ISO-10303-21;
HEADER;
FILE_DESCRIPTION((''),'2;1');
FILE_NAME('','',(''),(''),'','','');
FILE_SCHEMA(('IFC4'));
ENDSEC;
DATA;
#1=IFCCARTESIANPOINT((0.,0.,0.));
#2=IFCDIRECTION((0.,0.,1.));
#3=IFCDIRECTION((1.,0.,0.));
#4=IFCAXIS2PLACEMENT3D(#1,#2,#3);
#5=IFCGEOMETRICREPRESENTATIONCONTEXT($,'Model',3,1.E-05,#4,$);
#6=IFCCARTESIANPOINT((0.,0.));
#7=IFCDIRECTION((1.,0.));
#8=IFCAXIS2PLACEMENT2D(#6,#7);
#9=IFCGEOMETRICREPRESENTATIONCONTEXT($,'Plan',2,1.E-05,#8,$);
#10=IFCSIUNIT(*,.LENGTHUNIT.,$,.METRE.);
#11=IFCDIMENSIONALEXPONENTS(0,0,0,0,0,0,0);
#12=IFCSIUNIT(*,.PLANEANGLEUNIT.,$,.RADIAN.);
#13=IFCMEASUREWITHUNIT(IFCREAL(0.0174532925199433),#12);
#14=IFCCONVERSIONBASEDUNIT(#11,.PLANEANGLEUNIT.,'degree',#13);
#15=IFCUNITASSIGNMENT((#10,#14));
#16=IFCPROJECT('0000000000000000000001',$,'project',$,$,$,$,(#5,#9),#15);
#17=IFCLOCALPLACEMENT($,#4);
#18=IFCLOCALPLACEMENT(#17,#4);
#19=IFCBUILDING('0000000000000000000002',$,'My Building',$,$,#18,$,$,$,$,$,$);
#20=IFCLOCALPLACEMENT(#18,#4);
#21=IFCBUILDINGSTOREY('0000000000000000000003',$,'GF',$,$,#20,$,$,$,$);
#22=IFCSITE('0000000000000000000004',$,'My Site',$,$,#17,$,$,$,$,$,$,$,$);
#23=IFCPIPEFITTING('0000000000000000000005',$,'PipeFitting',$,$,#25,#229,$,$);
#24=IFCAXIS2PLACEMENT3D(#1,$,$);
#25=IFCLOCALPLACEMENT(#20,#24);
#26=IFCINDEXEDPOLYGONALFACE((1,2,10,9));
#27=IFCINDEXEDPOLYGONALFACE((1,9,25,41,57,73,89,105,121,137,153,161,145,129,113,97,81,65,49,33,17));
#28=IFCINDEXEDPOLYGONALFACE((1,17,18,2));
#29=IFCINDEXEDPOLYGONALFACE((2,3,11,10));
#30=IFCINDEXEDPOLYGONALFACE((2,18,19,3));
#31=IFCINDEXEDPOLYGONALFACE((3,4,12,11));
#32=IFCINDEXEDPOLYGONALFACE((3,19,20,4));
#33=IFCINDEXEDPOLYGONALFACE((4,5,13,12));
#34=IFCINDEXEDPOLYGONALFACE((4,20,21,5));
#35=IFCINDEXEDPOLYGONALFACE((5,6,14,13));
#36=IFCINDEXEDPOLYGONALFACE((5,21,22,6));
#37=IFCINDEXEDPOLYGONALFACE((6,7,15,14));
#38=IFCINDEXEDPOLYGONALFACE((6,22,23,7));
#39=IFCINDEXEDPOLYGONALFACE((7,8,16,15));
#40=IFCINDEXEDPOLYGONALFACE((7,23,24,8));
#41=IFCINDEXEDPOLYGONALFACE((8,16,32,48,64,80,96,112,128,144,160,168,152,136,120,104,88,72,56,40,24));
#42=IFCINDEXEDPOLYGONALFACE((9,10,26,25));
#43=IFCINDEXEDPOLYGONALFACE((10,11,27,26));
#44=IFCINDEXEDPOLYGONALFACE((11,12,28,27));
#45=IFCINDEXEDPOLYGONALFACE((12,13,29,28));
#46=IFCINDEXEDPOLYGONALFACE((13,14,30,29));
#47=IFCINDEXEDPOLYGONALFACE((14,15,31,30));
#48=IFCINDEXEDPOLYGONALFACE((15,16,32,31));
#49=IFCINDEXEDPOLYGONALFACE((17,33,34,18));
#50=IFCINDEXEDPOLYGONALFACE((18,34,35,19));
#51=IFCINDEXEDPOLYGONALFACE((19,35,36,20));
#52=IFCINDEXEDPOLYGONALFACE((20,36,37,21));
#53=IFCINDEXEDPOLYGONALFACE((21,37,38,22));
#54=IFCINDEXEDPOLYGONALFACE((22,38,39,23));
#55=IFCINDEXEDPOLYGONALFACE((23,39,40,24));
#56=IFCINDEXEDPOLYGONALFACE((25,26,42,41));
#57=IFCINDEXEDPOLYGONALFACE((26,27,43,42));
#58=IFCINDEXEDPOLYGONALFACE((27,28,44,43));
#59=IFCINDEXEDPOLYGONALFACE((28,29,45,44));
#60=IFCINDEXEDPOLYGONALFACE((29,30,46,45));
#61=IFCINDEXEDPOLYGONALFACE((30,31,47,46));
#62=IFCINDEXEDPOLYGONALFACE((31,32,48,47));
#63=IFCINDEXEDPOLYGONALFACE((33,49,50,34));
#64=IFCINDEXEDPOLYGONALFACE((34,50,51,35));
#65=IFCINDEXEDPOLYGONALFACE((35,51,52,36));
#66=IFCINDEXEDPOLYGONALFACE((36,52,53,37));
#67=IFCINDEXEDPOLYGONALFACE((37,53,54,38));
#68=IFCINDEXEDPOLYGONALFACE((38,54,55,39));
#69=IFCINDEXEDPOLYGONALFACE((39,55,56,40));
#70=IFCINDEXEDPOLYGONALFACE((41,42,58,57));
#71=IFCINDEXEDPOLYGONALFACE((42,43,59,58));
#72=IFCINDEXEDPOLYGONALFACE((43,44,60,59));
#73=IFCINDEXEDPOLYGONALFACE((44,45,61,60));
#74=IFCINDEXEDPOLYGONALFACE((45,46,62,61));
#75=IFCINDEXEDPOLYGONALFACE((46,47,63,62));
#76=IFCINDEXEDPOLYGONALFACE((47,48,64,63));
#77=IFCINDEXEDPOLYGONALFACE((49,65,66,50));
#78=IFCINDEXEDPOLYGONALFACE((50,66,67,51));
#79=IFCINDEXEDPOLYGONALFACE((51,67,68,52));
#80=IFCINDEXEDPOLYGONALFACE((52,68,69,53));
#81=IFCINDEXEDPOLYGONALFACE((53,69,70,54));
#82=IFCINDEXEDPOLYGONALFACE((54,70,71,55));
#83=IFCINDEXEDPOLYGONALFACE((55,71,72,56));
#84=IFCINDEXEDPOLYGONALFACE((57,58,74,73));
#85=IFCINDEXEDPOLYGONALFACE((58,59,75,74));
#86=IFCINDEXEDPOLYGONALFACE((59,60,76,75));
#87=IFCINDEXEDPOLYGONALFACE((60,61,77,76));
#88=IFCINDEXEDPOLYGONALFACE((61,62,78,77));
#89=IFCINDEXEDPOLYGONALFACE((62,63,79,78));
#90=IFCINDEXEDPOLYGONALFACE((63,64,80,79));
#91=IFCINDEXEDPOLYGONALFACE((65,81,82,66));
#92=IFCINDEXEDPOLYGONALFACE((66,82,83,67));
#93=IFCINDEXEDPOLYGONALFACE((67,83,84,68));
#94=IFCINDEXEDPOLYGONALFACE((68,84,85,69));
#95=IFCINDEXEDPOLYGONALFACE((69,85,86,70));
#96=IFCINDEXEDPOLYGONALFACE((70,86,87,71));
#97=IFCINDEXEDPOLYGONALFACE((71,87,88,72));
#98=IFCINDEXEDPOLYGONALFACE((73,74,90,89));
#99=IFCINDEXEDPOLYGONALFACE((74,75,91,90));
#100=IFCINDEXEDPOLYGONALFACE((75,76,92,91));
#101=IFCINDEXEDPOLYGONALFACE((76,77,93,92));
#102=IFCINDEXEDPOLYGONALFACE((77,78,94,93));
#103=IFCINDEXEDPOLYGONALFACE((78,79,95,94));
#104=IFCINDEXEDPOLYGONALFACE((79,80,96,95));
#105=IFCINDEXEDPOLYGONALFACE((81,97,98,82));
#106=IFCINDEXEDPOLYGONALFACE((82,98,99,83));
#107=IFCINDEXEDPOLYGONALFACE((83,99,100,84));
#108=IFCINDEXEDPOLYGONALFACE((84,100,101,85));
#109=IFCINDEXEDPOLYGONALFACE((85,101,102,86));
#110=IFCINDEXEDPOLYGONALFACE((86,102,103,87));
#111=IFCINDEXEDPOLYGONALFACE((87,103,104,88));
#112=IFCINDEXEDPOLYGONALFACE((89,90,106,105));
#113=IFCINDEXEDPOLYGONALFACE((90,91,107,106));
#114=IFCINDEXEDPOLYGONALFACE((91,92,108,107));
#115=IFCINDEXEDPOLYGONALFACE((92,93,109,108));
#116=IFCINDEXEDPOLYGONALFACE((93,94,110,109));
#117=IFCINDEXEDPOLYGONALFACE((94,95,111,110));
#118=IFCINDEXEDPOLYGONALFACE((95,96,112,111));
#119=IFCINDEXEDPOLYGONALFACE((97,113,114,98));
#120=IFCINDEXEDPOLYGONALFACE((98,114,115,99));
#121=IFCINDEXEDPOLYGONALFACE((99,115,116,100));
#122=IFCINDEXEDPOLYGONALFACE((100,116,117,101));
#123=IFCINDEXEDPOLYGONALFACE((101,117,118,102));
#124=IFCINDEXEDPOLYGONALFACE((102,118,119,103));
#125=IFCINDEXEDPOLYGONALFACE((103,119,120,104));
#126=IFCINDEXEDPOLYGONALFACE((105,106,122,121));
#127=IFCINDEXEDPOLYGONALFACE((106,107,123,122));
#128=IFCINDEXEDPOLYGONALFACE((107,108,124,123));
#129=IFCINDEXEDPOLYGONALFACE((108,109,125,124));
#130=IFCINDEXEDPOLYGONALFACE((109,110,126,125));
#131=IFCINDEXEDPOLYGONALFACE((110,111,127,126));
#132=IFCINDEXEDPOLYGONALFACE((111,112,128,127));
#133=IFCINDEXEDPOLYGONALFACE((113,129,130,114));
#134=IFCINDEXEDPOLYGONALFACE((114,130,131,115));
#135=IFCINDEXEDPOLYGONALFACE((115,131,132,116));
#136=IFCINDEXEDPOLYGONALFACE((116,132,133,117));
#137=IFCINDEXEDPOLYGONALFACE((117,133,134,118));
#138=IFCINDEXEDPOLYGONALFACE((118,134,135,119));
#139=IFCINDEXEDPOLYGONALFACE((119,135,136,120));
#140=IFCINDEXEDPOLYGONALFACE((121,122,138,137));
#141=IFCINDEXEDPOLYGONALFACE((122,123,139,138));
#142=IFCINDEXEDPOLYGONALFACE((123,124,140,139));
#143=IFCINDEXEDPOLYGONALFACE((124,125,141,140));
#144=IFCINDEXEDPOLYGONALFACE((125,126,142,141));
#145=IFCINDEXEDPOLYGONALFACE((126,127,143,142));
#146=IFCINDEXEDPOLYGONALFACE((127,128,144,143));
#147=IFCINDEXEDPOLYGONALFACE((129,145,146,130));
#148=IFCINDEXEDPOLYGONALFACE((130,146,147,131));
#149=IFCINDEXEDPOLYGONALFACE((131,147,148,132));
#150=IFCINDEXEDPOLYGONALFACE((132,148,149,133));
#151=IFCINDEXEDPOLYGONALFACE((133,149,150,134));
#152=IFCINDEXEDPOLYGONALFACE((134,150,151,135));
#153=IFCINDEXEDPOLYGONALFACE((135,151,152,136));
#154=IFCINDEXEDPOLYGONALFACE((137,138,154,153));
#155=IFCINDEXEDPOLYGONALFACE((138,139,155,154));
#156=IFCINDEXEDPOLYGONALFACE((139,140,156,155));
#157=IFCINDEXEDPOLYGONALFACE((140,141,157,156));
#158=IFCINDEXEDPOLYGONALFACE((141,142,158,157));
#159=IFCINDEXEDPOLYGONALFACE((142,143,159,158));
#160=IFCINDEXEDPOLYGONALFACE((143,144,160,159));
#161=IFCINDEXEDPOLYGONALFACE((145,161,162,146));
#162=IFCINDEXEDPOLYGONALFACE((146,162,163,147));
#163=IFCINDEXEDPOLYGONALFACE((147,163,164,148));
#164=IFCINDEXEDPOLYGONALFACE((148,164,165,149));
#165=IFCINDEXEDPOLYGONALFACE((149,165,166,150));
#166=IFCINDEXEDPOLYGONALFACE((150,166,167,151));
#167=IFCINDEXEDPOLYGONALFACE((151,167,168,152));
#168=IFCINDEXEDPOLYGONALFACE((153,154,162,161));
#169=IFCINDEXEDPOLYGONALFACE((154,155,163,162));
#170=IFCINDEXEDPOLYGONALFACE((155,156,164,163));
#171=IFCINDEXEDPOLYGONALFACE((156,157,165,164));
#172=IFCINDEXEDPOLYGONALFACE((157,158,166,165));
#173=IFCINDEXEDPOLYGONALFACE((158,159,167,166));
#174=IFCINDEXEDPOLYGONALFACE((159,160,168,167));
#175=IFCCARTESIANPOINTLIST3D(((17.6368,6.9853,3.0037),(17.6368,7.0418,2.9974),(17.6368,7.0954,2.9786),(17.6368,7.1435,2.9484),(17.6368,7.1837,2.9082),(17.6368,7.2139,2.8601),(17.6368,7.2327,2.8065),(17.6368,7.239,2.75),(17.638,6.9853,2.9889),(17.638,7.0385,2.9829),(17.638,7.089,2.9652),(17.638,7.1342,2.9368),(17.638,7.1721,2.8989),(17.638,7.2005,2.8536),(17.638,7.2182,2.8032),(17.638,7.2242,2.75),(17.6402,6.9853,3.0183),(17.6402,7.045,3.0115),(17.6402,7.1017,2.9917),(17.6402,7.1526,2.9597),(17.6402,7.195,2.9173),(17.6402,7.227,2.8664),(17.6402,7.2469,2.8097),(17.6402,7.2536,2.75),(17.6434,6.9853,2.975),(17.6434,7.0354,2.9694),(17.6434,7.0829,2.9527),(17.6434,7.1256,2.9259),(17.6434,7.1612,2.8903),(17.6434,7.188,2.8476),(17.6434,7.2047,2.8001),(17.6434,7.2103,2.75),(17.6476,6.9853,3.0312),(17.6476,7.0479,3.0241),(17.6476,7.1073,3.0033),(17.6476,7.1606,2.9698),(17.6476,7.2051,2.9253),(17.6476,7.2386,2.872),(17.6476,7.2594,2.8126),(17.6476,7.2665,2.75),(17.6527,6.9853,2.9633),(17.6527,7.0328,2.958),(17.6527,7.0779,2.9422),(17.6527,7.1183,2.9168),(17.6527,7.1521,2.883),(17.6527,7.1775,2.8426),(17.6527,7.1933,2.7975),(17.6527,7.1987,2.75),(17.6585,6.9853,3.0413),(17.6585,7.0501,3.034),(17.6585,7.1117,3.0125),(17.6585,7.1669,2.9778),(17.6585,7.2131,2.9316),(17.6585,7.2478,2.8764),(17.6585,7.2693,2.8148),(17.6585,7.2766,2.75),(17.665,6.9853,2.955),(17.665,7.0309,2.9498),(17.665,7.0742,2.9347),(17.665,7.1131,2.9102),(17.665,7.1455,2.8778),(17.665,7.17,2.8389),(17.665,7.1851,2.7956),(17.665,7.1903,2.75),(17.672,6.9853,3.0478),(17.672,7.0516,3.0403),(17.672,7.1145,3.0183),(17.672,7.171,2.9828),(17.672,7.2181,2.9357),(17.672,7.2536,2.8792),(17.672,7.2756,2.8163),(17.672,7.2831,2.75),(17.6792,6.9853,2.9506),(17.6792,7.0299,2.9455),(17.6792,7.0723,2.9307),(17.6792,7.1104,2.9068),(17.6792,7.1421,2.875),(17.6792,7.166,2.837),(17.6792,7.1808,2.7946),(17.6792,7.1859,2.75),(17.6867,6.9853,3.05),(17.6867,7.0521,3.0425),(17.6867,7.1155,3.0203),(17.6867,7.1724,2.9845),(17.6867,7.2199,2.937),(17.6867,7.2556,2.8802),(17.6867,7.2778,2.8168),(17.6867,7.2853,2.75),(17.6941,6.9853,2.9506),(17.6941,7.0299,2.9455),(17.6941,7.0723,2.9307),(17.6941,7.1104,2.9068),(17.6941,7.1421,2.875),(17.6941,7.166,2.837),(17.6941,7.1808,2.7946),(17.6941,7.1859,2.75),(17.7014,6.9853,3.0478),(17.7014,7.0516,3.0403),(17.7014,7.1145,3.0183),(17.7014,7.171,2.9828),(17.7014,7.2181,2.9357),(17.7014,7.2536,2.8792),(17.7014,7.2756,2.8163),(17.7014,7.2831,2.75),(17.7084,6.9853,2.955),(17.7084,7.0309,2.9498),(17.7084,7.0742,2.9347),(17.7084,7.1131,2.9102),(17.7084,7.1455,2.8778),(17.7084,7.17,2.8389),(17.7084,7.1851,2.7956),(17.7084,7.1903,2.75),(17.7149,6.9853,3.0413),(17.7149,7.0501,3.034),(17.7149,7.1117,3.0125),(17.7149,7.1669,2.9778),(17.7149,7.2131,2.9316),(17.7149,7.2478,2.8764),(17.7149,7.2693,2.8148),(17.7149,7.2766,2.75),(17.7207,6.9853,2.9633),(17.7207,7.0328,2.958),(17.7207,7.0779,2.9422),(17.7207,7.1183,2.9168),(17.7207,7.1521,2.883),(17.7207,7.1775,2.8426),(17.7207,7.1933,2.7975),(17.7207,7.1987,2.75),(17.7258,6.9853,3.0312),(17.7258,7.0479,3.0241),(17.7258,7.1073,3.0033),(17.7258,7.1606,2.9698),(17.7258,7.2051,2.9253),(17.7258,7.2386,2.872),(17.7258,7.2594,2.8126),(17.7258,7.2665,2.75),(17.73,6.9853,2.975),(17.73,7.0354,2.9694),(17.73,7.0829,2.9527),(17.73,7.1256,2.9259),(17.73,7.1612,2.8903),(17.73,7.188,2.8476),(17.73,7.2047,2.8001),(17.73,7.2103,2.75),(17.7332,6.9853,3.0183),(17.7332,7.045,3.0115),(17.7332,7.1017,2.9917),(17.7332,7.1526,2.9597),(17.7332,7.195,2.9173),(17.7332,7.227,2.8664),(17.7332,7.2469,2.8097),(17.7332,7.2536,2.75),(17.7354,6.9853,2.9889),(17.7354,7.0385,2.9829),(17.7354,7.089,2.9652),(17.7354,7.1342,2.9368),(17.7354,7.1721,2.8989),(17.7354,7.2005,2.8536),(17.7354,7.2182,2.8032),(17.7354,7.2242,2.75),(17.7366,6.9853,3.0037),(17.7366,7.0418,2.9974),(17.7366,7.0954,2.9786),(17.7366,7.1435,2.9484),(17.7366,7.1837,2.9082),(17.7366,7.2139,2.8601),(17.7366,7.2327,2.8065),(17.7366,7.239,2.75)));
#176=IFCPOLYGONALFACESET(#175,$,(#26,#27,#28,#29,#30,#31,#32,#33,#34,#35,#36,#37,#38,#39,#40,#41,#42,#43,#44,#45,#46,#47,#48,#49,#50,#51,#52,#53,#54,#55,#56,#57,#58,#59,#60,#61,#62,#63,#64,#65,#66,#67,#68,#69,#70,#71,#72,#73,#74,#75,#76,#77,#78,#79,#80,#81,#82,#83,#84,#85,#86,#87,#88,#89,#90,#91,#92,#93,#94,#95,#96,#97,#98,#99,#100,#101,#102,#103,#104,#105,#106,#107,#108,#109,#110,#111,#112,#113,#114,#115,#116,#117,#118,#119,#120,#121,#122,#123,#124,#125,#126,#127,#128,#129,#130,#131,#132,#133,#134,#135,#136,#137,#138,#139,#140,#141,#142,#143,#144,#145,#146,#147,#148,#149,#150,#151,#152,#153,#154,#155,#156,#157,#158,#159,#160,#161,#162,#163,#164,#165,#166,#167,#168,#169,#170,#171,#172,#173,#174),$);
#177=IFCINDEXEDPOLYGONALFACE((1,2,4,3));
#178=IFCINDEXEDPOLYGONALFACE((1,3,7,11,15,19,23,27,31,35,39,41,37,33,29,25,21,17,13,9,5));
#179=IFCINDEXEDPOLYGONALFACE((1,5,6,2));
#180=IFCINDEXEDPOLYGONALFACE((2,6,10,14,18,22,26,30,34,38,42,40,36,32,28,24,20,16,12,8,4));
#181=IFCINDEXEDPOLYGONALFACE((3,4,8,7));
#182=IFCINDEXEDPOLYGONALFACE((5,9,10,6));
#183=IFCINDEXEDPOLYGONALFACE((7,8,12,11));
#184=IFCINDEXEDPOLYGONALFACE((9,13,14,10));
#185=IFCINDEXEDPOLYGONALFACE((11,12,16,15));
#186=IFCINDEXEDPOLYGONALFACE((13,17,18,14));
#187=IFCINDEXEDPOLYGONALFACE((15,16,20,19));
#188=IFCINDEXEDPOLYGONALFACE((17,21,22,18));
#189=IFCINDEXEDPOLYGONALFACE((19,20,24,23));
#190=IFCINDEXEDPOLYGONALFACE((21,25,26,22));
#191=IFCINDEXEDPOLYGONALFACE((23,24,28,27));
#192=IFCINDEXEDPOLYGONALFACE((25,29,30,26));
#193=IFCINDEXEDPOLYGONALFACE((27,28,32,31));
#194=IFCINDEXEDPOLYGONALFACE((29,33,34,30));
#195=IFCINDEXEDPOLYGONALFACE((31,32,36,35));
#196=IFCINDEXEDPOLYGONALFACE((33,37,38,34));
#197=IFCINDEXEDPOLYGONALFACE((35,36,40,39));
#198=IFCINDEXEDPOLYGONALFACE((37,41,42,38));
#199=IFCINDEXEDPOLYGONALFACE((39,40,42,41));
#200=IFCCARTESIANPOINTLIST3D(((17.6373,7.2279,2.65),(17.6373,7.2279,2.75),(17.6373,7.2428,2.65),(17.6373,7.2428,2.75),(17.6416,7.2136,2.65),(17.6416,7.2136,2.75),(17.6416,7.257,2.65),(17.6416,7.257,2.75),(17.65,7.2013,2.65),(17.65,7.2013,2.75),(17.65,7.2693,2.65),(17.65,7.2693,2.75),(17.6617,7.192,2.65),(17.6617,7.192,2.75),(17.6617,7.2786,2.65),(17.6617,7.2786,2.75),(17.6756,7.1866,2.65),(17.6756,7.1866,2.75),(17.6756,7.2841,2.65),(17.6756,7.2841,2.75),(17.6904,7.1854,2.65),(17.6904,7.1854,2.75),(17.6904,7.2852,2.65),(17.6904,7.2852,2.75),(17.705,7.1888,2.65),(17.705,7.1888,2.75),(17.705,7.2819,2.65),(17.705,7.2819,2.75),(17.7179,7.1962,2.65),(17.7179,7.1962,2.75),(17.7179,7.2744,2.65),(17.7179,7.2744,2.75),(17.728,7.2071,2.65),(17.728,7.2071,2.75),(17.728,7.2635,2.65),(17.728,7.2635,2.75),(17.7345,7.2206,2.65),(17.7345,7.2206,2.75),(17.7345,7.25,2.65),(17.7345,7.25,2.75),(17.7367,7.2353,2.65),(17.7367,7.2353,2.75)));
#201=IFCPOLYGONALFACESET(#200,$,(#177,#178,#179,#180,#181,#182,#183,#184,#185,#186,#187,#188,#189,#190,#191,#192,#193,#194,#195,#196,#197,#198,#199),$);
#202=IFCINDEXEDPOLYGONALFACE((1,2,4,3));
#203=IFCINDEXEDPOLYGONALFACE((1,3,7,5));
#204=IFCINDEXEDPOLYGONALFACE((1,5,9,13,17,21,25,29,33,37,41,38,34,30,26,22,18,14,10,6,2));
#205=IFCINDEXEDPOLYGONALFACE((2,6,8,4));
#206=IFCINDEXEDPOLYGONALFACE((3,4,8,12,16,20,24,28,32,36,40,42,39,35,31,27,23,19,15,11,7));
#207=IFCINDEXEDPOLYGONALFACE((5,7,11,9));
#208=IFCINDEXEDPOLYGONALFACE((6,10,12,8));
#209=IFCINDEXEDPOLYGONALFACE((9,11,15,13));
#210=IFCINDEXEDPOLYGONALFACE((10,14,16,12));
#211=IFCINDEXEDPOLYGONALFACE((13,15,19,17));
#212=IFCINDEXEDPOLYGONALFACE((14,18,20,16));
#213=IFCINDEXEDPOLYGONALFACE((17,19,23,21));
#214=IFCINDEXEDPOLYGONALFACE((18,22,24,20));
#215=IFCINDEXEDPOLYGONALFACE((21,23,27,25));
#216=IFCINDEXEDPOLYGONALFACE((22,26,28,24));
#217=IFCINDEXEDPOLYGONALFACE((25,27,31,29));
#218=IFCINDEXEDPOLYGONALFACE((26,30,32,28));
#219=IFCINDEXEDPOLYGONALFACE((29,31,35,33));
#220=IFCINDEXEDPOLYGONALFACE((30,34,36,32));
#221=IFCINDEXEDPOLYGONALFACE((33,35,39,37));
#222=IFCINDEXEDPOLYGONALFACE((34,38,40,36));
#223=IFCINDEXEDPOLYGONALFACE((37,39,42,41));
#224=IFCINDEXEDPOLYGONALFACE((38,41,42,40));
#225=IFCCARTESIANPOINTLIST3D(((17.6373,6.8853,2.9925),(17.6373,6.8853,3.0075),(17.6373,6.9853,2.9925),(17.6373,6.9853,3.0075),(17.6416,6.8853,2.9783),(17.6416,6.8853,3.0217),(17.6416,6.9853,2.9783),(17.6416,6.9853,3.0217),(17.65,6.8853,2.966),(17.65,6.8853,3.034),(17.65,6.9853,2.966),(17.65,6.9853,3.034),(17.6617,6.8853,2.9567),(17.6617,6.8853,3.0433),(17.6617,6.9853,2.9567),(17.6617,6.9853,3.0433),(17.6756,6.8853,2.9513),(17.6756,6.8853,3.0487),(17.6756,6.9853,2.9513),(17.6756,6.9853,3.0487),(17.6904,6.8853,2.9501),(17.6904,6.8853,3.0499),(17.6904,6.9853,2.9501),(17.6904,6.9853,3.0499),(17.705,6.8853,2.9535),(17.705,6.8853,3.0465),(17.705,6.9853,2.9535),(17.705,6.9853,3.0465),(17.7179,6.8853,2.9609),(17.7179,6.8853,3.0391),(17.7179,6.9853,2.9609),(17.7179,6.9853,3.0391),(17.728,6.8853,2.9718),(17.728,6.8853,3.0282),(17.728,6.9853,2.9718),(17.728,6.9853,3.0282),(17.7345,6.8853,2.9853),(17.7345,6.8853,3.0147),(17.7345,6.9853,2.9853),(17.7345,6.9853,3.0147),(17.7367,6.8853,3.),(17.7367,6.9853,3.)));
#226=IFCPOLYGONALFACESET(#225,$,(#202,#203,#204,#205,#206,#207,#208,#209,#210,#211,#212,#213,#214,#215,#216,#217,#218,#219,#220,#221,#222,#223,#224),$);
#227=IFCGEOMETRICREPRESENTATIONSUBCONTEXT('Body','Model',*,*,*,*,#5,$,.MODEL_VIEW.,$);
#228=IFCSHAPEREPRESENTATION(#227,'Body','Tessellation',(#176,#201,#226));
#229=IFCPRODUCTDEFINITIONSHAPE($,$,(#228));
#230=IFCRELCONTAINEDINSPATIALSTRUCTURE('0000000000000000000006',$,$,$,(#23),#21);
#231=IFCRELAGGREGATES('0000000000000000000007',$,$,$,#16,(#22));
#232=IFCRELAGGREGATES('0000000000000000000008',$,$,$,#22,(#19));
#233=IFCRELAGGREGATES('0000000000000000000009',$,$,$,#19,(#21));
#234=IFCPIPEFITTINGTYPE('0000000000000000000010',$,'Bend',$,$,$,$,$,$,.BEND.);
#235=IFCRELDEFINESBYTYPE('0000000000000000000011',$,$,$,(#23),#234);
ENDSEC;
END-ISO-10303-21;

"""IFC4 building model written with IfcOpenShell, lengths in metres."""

from ifc_helpers import new_model, entity, si_unit, converted_unit, frame, origin_with_axes, origin_2d_with_axis, place, context, subcontext, project, spatial, circle, extrude, source, transform, mapped, type_object, type_shapes, element, save


model = new_model("IFC4")

# Units and contexts
model_context = context("Model", 3, precision=1e-05, world=origin_with_axes())
plan_context = context("Plan", 2, precision=1e-05, world=origin_2d_with_axis())
body_context_1 = subcontext(model_context, "Body", "Model", "MODEL_VIEW")
ifc_project = project(units=[si_unit("LENGTHUNIT", "METRE"), converted_unit("PLANEANGLEUNIT", "degree", entity("IfcReal", 0.0174532925199433), si_unit("PLANEANGLEUNIT", "RADIAN"), dimensions=[0, 0, 0, 0, 0, 0, 0])], contexts=[model_context, plan_context])

# Site, building, storey
site_placement = place(None, origin_with_axes())
site = spatial("IfcSite", under=ifc_project, at=site_placement, Name="My Site")
building_placement = place(site_placement, origin_with_axes())
building = spatial("IfcBuilding", under=site, at=building_placement, Name="My Building")
storey_placement = place(building_placement, origin_with_axes())
storey = spatial("IfcBuildingStorey", under=building, at=storey_placement, Name="GF")

# Pipe fitting
pipe_fitting_type = type_object("IfcPipeFittingType", Name="Bend", PredefinedType="BEND")
shared_shape_1 = source(origin_with_axes(), body_context_1, "Body", "SolidModel", [
    entity("IfcSweptDiskSolid", entity("IfcIndexedPolyCurve", entity("IfcCartesianPointList3D", [[0.0, 0.0, -0.1], [0.0, 0.0732, -0.2768], [0.0, 0.25, -0.35]]), [entity("IfcArcIndex", [1, 2, 3])]), 0.05),
    extrude(circle(Radius=0.05), origin_with_axes(), (0.0, 0.0, -1.0), 0.1),
    extrude(circle(Radius=0.05), frame((0.0, 0.25, -0.35), z_axis=(0.0, 1.0, 0.0), x_axis=(1.0, 0.0, 0.0)), (0.0, 0.0, 1.0), 0.1),
])
type_shapes(pipe_fitting_type, [shared_shape_1])
for number, where, z_axis, x_axis, name in (
    (1, (17.6867, 7.2353, 2.65), (0.0, 0.0, -1.0), (1.0, 0.0, 0.0), "PipeFitting"),
):
    element("IfcPipeFitting", number, at=place(storey_placement, frame(where, z_axis=z_axis, x_axis=x_axis)), inside=storey, type_object=pipe_fitting_type, Name=name, context=body_context_1, shape_type="MappedRepresentation", body=[
        mapped(shared_shape_1, transform((0.0, 0.0, 0.0), x_axis=(1.0, 0.0, 0.0), y_axis=(0.0, 1.0, 0.0), z_axis=(0.0, 0.0, 1.0), scale=1.0)),
    ])

save(model, "model.ifc")
